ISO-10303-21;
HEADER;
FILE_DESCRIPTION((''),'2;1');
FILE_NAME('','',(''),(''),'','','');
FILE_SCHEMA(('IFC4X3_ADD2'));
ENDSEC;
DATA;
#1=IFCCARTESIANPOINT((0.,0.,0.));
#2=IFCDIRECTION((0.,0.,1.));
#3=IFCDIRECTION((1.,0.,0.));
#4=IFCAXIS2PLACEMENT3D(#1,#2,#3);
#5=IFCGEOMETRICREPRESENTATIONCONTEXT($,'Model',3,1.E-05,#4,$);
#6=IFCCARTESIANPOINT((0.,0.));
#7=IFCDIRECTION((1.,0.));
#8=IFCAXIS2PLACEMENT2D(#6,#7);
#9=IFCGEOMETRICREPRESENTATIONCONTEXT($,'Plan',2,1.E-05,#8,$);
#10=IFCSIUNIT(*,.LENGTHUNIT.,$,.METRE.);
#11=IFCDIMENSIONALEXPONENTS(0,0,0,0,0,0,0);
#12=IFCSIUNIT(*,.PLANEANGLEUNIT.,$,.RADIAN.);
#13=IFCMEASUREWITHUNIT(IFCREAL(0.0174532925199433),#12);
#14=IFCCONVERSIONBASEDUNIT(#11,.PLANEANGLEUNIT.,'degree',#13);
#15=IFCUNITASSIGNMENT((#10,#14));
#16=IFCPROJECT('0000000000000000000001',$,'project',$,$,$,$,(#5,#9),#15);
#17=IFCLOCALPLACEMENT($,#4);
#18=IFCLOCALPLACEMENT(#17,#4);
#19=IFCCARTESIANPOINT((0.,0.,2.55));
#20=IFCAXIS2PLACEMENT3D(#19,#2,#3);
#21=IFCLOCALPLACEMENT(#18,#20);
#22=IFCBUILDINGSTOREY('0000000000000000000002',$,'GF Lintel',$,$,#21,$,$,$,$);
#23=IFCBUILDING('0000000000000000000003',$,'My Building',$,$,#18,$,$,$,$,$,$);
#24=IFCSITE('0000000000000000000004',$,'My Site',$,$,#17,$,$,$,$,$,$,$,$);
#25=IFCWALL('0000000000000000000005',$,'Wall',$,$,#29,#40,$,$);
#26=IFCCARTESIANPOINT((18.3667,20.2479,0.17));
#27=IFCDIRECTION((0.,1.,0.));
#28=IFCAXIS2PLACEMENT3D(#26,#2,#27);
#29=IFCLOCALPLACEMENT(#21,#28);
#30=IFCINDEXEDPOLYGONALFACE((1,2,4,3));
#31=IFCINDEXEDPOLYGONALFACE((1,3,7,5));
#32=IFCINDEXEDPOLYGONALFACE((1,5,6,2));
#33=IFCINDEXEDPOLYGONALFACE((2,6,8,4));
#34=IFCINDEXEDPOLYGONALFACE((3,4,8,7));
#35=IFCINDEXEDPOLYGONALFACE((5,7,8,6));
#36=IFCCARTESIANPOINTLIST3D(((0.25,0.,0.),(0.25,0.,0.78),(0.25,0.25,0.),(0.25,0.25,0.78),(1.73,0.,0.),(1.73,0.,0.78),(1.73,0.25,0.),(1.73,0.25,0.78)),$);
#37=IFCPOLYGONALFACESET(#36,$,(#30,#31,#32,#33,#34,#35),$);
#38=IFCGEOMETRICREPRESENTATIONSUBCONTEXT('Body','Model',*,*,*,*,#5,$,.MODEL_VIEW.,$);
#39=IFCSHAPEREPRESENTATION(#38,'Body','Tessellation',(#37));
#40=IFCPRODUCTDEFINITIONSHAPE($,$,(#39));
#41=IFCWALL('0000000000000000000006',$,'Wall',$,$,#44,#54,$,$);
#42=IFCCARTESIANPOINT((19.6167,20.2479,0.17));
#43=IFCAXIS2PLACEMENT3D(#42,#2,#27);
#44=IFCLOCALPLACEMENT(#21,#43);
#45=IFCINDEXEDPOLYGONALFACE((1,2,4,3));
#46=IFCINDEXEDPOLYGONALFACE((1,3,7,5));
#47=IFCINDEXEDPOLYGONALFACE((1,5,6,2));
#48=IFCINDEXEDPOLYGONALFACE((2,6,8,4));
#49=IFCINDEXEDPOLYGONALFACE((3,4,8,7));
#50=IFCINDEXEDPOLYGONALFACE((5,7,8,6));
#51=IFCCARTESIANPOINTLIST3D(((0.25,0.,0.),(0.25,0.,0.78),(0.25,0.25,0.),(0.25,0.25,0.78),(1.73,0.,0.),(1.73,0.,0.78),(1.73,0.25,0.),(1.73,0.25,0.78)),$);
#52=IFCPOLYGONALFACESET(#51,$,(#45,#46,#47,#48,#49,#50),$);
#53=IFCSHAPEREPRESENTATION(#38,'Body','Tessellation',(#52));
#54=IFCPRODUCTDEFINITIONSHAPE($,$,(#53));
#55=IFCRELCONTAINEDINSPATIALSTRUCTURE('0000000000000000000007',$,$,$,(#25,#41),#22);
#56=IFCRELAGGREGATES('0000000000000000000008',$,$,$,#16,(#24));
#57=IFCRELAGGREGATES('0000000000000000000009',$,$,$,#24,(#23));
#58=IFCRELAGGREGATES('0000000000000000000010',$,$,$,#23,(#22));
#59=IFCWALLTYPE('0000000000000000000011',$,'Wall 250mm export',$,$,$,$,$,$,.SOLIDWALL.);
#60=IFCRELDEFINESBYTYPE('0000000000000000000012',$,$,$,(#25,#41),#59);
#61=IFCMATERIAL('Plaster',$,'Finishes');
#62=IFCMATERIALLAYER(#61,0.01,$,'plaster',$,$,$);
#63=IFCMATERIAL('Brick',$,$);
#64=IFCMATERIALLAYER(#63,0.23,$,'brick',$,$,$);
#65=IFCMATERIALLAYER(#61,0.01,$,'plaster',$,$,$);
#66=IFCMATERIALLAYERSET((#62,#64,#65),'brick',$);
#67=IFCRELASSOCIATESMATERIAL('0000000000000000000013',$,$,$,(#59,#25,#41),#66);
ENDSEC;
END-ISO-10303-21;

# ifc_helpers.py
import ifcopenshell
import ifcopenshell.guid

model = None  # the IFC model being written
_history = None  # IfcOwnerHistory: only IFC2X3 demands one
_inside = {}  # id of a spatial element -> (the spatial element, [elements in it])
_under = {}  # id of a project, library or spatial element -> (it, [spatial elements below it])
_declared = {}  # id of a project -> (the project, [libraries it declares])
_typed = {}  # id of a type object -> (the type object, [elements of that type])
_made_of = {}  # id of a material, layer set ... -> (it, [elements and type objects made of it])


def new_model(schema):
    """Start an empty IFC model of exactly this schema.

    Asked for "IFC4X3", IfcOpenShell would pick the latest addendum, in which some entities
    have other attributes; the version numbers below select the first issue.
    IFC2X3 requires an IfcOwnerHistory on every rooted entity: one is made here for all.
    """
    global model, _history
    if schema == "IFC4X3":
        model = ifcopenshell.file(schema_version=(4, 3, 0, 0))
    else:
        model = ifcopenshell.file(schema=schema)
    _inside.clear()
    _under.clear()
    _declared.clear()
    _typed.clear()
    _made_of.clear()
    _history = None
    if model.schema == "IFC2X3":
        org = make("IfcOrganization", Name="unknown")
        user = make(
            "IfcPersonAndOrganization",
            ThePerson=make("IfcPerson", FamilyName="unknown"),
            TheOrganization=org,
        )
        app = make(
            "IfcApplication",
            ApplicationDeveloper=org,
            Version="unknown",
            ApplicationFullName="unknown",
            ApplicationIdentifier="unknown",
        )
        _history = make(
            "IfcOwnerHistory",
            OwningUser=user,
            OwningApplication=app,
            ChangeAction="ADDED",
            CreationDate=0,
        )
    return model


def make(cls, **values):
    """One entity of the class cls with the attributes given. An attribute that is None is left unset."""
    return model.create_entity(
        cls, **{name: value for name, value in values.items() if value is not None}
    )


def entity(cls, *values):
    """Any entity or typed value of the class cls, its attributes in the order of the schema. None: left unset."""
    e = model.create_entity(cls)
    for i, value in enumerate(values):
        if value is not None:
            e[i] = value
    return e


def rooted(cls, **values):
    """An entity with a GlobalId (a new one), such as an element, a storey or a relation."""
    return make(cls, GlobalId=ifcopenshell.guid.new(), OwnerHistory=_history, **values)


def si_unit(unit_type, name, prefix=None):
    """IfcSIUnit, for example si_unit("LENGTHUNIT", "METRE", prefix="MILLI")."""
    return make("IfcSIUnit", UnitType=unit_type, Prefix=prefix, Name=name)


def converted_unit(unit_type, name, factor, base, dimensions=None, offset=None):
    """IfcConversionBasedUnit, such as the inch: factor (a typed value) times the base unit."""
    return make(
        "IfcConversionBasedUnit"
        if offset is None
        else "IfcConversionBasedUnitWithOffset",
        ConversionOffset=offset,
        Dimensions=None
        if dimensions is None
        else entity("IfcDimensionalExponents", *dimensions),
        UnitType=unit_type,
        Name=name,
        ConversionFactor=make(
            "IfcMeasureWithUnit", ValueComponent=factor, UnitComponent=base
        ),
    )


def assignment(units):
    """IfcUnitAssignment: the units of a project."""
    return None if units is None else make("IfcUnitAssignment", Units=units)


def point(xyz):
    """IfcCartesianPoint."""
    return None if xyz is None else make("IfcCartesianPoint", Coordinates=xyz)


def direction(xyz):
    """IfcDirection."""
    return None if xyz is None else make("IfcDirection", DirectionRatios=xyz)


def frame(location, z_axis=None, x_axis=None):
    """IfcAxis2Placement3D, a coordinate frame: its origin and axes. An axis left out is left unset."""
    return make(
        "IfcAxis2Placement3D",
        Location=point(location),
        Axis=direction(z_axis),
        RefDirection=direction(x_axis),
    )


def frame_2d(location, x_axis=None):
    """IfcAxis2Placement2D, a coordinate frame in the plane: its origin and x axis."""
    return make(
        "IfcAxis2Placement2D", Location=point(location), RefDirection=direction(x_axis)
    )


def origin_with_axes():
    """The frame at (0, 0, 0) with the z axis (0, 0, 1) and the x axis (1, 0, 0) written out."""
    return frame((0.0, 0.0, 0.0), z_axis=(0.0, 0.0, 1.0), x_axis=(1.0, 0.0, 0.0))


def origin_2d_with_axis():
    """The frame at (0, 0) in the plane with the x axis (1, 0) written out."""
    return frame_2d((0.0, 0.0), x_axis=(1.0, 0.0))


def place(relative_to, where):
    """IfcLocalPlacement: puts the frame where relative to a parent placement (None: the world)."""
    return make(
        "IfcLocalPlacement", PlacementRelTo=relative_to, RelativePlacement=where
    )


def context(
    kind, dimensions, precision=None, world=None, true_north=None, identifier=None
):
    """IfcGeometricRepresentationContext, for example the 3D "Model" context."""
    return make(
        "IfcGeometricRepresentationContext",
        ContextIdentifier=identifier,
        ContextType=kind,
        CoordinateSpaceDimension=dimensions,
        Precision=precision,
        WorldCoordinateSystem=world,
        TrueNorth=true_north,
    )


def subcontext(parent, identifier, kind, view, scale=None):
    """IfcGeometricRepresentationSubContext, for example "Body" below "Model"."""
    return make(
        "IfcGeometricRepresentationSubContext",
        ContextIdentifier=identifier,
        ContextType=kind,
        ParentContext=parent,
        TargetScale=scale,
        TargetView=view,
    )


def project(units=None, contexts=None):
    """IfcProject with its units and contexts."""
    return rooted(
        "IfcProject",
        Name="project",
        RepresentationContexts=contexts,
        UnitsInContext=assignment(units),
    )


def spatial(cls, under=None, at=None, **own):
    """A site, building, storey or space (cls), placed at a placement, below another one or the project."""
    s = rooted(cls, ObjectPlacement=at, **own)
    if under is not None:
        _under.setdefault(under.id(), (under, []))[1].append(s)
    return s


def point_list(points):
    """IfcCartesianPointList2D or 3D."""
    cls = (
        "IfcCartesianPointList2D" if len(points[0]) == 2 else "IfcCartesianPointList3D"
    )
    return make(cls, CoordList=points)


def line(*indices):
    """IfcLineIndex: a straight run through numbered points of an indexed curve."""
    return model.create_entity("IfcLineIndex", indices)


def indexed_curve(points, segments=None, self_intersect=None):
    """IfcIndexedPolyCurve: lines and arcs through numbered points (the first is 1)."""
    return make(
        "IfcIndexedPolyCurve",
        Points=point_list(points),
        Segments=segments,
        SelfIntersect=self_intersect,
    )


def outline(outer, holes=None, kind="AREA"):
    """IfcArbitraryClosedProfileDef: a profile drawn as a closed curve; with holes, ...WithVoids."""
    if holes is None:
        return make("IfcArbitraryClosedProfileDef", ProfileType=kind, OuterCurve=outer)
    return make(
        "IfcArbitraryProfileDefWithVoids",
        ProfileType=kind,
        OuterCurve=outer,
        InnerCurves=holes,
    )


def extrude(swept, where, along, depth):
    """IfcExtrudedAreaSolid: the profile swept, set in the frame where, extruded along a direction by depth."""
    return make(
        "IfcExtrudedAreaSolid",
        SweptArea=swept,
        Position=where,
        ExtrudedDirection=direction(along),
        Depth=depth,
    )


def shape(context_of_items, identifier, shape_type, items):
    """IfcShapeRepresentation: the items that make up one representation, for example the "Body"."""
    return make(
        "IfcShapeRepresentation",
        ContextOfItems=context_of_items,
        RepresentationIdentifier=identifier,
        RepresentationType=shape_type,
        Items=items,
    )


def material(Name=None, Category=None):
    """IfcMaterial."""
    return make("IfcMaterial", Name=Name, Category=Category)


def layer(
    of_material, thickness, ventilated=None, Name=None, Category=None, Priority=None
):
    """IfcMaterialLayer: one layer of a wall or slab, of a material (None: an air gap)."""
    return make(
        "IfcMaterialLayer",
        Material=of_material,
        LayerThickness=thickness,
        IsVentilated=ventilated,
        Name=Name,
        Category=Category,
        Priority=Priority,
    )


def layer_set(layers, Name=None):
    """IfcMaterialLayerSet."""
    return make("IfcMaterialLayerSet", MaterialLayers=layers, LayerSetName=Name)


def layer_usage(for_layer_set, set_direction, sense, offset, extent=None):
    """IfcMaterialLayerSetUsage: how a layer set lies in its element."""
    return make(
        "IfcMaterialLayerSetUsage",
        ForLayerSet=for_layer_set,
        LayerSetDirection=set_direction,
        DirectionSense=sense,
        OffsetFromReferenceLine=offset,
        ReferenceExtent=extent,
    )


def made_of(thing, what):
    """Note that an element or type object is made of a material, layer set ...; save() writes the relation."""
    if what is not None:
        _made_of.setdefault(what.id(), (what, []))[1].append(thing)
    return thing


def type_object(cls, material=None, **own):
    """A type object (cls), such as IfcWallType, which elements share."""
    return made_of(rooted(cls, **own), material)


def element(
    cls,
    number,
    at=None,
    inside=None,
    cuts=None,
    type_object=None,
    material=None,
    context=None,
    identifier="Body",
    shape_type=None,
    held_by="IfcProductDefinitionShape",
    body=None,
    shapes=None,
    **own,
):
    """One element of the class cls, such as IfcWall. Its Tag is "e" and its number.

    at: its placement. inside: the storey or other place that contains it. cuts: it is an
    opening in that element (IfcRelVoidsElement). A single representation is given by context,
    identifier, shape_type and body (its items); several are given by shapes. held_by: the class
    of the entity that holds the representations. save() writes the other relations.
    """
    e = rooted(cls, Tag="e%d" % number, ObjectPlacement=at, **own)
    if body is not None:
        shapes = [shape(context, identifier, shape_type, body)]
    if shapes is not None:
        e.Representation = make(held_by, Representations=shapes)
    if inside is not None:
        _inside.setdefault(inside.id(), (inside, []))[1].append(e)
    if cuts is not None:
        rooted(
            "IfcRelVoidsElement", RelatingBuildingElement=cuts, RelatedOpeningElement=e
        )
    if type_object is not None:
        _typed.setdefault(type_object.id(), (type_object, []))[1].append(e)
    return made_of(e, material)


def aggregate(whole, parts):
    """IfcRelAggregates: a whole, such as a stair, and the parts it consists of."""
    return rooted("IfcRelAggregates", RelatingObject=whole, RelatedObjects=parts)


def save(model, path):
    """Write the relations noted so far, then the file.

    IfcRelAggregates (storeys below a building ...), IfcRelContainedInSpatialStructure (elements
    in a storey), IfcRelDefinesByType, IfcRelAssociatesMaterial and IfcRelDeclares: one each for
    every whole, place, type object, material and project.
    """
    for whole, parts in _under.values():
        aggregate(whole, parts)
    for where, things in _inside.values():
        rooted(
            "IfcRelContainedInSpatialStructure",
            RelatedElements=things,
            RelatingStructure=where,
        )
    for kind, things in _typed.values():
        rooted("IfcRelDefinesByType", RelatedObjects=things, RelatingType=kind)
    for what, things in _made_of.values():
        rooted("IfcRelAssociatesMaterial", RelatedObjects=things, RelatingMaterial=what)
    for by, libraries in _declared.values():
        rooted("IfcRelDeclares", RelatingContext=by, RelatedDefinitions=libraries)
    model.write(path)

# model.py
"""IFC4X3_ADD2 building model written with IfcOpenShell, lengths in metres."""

from ifc_helpers import new_model, entity, si_unit, converted_unit, frame, origin_with_axes, origin_2d_with_axis, place, context, subcontext, project, spatial, line, indexed_curve, outline, extrude, material, layer, layer_set, layer_usage, type_object, element, save


model = new_model("IFC4X3_ADD2")

# Units and contexts
model_context = context("Model", 3, precision=1e-05, world=origin_with_axes())
plan_context = context("Plan", 2, precision=1e-05, world=origin_2d_with_axis())
body_context = subcontext(model_context, "Body", "Model", "MODEL_VIEW")
ifc_project = project(units=[si_unit("LENGTHUNIT", "METRE"), converted_unit("PLANEANGLEUNIT", "degree", entity("IfcReal", 0.0174532925199433), si_unit("PLANEANGLEUNIT", "RADIAN"), dimensions=[0, 0, 0, 0, 0, 0, 0])], contexts=[model_context, plan_context])

# Site, building, storey
site_placement = place(None, origin_with_axes())
site = spatial("IfcSite", under=ifc_project, at=site_placement, Name="My Site")
building_placement = place(site_placement, origin_with_axes())
building = spatial("IfcBuilding", under=site, at=building_placement, Name="My Building")
storey_placement = place(building_placement, frame((0.0, 0.0, 2.55), z_axis=(0.0, 0.0, 1.0), x_axis=(1.0, 0.0, 0.0)))
storey = spatial("IfcBuildingStorey", under=building, at=storey_placement, Name="GF Lintel")

# Walls
ifc_material_1 = material(Name="Plaster", Category="Finishes")
ifc_layer_1 = layer(ifc_material_1, 0.01, Name="plaster")
ifc_material_2 = material(Name="Brick")
ifc_layer_2 = layer(ifc_material_2, 0.23, Name="brick")
ifc_layer_3 = layer(ifc_material_1, 0.01, Name="plaster")
ifc_layer_set_1 = layer_set([ifc_layer_1, ifc_layer_2, ifc_layer_3], Name="brick")
ifc_layer_usage_1 = layer_usage(ifc_layer_set_1, "AXIS2", "POSITIVE", 0.0)
wall_type_1 = type_object("IfcWallType", Name="Wall 250mm export", PredefinedType="SOLIDWALL", material=ifc_layer_set_1)
wall_1_placement = place(storey_placement, frame((18.3667, 20.2479, 0.17), z_axis=(0.0, 0.0, 1.0), x_axis=(0.0, 1.0, 0.0)))
element("IfcWall", 1, at=wall_1_placement, inside=storey, type_object=wall_type_1, material=ifc_layer_usage_1, Name="Wall", context=body_context, shape_type="SweptSolid", body=[
    extrude(outline(indexed_curve([(0.25, 0.0), (0.25, 0.25), (1.73, 0.25), (1.73, 0.0)], segments=[line(1, 2, 3, 4, 1)])), origin_with_axes(), (0.0, 0.0, 1.0), 0.78),
])
ifc_layer_usage_2 = layer_usage(ifc_layer_set_1, "AXIS2", "POSITIVE", 0.0)
wall_2_placement = place(storey_placement, frame((19.6167, 20.2479, 0.17), z_axis=(0.0, 0.0, 1.0), x_axis=(0.0, 1.0, 0.0)))
element("IfcWall", 2, at=wall_2_placement, inside=storey, type_object=wall_type_1, material=ifc_layer_usage_2, Name="Wall", context=body_context, shape_type="SweptSolid", body=[
    extrude(outline(indexed_curve([(0.25, 0.0), (0.25, 0.25), (1.73, 0.25), (1.73, 0.0)], segments=[line(1, 2, 3, 4, 1)])), origin_with_axes(), (0.0, 0.0, 1.0), 0.78),
])

save(model, "model.ifc")
